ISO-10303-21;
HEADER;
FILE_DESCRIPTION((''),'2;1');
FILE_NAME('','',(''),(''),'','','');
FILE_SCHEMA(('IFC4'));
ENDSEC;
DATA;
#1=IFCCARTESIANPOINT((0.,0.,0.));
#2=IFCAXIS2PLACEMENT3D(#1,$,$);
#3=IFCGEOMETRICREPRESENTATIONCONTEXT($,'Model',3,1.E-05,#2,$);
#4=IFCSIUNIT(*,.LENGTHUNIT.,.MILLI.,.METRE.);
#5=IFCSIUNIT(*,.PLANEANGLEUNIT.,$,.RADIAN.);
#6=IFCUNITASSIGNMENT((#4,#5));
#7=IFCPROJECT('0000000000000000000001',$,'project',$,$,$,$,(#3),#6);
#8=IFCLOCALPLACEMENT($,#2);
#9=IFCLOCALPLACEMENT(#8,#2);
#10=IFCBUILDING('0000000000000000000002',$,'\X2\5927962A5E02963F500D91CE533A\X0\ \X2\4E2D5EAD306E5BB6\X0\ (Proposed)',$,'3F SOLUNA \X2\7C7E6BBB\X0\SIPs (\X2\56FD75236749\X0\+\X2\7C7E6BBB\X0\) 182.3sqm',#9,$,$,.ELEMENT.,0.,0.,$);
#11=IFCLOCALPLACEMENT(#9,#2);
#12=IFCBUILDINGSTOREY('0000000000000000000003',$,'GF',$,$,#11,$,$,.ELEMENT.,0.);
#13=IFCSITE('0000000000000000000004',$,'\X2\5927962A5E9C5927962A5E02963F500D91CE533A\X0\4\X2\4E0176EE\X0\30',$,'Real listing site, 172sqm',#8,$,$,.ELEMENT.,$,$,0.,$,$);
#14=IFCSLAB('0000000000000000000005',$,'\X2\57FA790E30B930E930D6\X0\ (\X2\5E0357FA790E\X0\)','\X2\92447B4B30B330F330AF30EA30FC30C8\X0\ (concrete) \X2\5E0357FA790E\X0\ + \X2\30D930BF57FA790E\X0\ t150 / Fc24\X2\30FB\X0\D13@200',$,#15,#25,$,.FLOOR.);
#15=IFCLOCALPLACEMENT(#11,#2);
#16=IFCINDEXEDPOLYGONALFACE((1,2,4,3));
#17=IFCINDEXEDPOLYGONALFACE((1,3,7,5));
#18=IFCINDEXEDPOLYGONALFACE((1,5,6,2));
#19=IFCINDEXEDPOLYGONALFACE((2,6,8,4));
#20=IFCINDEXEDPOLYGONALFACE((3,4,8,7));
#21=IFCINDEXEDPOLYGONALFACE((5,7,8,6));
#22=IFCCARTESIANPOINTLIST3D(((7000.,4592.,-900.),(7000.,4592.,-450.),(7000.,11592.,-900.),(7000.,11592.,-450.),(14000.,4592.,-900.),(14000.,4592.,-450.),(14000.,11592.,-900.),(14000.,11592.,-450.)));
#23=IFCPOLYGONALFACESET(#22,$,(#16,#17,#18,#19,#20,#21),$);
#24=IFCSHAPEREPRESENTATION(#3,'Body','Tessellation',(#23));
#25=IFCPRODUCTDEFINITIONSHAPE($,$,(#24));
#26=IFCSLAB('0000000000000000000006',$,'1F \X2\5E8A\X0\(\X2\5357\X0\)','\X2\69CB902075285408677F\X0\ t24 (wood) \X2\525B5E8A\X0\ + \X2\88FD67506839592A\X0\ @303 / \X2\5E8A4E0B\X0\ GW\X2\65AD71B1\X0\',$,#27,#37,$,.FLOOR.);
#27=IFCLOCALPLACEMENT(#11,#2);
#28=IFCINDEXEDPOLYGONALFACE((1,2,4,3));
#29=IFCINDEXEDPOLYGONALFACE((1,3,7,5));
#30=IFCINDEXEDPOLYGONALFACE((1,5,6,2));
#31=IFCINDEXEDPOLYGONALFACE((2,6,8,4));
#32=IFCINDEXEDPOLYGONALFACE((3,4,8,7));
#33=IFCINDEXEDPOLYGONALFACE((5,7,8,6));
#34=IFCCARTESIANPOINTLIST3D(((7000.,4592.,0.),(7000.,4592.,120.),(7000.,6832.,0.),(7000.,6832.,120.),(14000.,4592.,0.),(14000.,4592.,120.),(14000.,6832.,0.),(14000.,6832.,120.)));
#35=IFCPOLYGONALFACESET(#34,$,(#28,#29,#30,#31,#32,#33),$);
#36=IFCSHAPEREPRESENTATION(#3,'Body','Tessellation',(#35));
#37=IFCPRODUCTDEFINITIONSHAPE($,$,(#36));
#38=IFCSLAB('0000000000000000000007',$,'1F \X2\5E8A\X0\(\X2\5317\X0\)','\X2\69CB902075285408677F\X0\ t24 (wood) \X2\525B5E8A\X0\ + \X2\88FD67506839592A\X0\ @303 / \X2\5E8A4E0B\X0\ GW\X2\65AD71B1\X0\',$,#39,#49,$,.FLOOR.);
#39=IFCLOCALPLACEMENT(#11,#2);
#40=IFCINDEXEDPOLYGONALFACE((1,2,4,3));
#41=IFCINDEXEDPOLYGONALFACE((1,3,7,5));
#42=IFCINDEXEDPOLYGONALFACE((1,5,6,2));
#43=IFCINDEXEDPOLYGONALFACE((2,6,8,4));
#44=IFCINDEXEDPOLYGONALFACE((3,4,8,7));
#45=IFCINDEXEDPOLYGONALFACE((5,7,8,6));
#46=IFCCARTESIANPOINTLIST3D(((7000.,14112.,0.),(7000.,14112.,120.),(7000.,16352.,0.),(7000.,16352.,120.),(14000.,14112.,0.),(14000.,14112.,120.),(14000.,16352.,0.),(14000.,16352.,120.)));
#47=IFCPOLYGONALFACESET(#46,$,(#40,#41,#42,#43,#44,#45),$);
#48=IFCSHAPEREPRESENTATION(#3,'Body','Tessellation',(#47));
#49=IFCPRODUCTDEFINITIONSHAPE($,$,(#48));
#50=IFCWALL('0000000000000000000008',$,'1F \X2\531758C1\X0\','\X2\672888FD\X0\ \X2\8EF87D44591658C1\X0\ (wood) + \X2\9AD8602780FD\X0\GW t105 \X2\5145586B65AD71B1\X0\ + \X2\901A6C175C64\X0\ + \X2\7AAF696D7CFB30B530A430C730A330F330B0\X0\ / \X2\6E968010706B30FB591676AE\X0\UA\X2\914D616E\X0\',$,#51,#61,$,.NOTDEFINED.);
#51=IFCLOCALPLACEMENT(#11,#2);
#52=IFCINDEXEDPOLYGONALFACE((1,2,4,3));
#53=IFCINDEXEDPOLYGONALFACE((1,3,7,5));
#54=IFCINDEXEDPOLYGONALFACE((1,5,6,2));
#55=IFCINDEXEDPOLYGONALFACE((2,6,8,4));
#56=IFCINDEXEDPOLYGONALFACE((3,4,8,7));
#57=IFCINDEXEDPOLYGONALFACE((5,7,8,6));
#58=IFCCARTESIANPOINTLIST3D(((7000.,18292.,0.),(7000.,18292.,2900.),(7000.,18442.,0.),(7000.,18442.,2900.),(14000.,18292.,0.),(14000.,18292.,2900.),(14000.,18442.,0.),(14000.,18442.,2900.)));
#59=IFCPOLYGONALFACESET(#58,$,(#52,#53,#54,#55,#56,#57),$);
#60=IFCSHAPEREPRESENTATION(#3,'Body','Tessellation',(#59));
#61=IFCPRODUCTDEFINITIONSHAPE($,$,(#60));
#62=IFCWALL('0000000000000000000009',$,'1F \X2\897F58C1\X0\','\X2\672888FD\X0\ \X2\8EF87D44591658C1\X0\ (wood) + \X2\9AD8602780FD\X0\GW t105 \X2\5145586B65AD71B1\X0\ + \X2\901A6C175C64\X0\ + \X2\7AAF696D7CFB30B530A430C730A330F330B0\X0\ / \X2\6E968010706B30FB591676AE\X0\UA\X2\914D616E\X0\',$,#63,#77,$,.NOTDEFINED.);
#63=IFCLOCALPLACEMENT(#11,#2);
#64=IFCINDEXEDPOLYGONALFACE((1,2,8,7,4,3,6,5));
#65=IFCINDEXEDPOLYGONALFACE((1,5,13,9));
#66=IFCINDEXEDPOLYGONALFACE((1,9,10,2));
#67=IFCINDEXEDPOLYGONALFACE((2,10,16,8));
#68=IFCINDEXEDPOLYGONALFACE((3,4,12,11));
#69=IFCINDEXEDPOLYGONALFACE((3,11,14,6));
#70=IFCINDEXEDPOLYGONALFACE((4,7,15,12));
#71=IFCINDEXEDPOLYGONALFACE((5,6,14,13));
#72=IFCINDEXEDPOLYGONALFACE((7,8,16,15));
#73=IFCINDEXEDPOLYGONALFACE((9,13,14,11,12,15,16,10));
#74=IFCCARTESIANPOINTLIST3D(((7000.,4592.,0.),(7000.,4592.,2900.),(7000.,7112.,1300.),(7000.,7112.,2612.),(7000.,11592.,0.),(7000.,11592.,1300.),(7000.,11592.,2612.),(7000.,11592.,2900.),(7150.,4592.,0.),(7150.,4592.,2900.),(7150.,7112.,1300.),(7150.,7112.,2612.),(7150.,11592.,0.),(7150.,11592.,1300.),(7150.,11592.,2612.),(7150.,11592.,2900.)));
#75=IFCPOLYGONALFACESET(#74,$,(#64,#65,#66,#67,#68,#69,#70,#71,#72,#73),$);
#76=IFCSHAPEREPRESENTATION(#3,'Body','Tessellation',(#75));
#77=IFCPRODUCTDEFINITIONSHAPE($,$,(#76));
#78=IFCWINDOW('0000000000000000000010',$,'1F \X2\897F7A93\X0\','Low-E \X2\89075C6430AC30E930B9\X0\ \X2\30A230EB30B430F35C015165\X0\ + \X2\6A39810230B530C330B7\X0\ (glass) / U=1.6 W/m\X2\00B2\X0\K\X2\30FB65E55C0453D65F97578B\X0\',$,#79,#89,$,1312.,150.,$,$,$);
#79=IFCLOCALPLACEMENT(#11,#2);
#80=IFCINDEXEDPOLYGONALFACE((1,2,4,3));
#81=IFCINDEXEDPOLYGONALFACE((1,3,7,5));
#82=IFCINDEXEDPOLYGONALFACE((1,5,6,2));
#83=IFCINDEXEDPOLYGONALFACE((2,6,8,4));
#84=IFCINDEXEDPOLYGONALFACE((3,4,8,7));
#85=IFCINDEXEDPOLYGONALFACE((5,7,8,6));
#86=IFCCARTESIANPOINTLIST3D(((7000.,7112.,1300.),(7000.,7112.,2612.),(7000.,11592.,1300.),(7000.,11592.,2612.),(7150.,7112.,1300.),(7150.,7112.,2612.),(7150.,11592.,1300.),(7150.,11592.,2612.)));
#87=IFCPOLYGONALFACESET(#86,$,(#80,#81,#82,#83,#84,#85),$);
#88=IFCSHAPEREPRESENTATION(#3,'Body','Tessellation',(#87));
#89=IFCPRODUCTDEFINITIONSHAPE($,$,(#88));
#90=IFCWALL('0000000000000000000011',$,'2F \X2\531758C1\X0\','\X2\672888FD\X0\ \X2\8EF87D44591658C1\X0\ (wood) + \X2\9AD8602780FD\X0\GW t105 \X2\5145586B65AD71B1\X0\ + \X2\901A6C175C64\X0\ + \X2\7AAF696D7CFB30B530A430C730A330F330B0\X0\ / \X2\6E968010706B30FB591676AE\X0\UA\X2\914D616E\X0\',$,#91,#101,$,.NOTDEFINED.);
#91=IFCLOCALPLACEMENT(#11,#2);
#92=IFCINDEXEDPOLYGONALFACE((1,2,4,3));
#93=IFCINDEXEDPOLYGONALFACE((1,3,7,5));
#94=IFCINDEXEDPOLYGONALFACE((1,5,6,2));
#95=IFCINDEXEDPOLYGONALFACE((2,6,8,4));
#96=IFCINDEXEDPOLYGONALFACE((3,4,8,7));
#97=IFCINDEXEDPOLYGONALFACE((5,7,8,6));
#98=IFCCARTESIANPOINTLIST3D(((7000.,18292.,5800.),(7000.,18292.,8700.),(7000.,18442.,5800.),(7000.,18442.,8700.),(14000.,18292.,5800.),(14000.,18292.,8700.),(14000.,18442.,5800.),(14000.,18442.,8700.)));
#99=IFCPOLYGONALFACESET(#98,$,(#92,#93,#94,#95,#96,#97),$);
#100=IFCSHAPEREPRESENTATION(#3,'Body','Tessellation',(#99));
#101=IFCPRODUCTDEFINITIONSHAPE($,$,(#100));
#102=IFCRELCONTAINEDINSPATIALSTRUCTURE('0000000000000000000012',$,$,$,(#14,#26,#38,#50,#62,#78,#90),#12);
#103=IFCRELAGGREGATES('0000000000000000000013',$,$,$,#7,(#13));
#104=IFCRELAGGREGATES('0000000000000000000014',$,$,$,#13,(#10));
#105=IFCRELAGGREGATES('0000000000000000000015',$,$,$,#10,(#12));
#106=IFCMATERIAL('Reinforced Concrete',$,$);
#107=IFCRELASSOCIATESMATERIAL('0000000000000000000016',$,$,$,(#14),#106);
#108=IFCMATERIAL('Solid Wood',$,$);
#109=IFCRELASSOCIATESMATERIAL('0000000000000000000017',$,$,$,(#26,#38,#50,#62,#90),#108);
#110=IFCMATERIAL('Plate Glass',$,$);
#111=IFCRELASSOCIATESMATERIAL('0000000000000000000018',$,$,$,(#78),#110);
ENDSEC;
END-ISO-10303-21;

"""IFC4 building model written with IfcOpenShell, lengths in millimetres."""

from ifc_helpers import new_model, si_unit, frame, frame_2d, origin, place, context, project, spatial, rectangle, extrude, material, element, fill, save


model = new_model("IFC4")

# Units and contexts
model_context = context("Model", 3, precision=1e-05, world=origin())
ifc_project = project(units=[si_unit("LENGTHUNIT", "METRE", prefix="MILLI"), si_unit("PLANEANGLEUNIT", "RADIAN")], contexts=[model_context])

# Site, building, storey
site_placement = place(None, origin())
site = spatial("IfcSite", under=ifc_project, at=site_placement, Name="大阪府大阪市阿倍野区4丁目30", ObjectType="Real listing site, 172sqm", CompositionType="ELEMENT", RefElevation=0.0)
building_placement = place(site_placement, origin())
building = spatial("IfcBuilding", under=site, at=building_placement, Name="大阪市阿倍野区 中庭の家 (Proposed)", ObjectType="3F SOLUNA 籾殻SIPs (国産杉+籾殻) 182.3sqm", CompositionType="ELEMENT", ElevationOfRefHeight=0.0, ElevationOfTerrain=0.0)
storey_placement = place(building_placement, origin())
storey = spatial("IfcBuildingStorey", under=building, at=storey_placement, Name="GF", CompositionType="ELEMENT", Elevation=0.0)

# Slabs
ifc_material_1 = material(Name="Reinforced Concrete")
slab_1_placement = place(storey_placement, frame((3500.0, 2296.0, -450.0)))
element("IfcSlab", 1, at=slab_1_placement, inside=storey, material=ifc_material_1, Name="基礎スラブ (布基礎)", Description="鉄筋コンクリート (concrete) 布基礎 + ベタ基礎 t150 / Fc24・D13@200", PredefinedType="FLOOR", context=model_context, shape_type="SweptSolid", body=[
    extrude(rectangle(XDim=7000.0, YDim=7000.0, at=frame_2d((3500.0, 3500.0))), frame((3500.0, 2296.0, -450.0)), (0.0, 0.0, 1.0), 450.0),
])
ifc_material_2 = material(Name="Solid Wood")
slab_2_placement = place(storey_placement, frame((3500.0, 2296.0, 0.0)))
element("IfcSlab", 2, at=slab_2_placement, inside=storey, material=ifc_material_2, Name="1F 床(南)", Description="構造用合板 t24 (wood) 剛床 + 製材根太 @303 / 床下 GW断熱", PredefinedType="FLOOR", context=model_context, shape_type="SweptSolid", body=[
    extrude(rectangle(XDim=7000.0, YDim=2240.0, at=frame_2d((3500.0, 1120.0))), frame((3500.0, 2296.0, 0.0)), (0.0, 0.0, 1.0), 120.0),
])
slab_3_placement = place(storey_placement, frame((3500.0, 7056.0, 0.0)))
element("IfcSlab", 3, at=slab_3_placement, inside=storey, material=ifc_material_2, Name="1F 床(北)", Description="構造用合板 t24 (wood) 剛床 + 製材根太 @303 / 床下 GW断熱", PredefinedType="FLOOR", context=model_context, shape_type="SweptSolid", body=[
    extrude(rectangle(XDim=7000.0, YDim=2240.0, at=frame_2d((3500.0, 1120.0))), frame((3500.0, 7056.0, 0.0)), (0.0, 0.0, 1.0), 120.0),
])

# Shared definitions
ifc_material_3 = material(Name="Plate Glass")

# Wall
wall_1_placement = place(storey_placement, frame((3500.0, 9146.0, 0.0)))
element("IfcWall", 4, at=wall_1_placement, inside=storey, material=ifc_material_2, Name="1F 北壁", Description="木製 軸組外壁 (wood) + 高性能GW t105 充填断熱 + 通気層 + 窯業系サイディング / 準耐火・外皮UA配慮", PredefinedType="NOTDEFINED", context=model_context, shape_type="SweptSolid", body=[
    extrude(rectangle(XDim=7000.0, YDim=150.0, at=frame_2d((3500.0, 75.0))), frame((3500.0, 9146.0, 0.0)), (0.0, 0.0, 1.0), 2900.0),
])

# Wall, opening, window
wall_2_placement = place(storey_placement, frame((3500.0, 2296.0, 0.0)))
wall_2 = element("IfcWall", 5, at=wall_2_placement, inside=storey, material=ifc_material_2, Name="1F 西壁", Description="木製 軸組外壁 (wood) + 高性能GW t105 充填断熱 + 通気層 + 窯業系サイディング / 準耐火・外皮UA配慮", PredefinedType="NOTDEFINED", context=model_context, shape_type="SweptSolid", body=[
    extrude(rectangle(XDim=150.0, YDim=7000.0, at=frame_2d((75.0, 3500.0))), frame((3500.0, 2296.0, 0.0)), (0.0, 0.0, 1.0), 2900.0),
])
opening_1_placement = place(storey_placement, frame((3500.0, 3556.0, 650.0)))
opening_1 = element("IfcOpeningElement", 6, at=opening_1_placement, cuts=wall_2, PredefinedType="NOTDEFINED", context=model_context, shape_type="SweptSolid", body=[
    extrude(rectangle(XDim=150.0, YDim=4480.0, at=frame_2d((75.0, 2240.0))), frame((3500.0, 3556.0, 650.0)), (0.0, 0.0, 1.0), 1312.0),
])
window_1_placement = place(storey_placement, frame((3500.0, 3556.0, 650.0)))
window_1 = element("IfcWindow", 7, at=window_1_placement, inside=storey, material=ifc_material_3, Name="1F 西窓", Description="Low-E 複層ガラス アルゴン封入 + 樹脂サッシ (glass) / U=1.6 W/m²K・日射取得型", OverallHeight=1312.0, OverallWidth=150.0, context=model_context, shape_type="SweptSolid", body=[
    extrude(rectangle(XDim=150.0, YDim=4480.0, at=frame_2d((75.0, 2240.0))), frame((3500.0, 3556.0, 650.0)), (0.0, 0.0, 1.0), 1312.0),
])
fill(opening_1, window_1)

# Wall
wall_3_placement = place(storey_placement, frame((3500.0, 9146.0, 2900.0)))
element("IfcWall", 8, at=wall_3_placement, inside=storey, material=ifc_material_2, Name="2F 北壁", Description="木製 軸組外壁 (wood) + 高性能GW t105 充填断熱 + 通気層 + 窯業系サイディング / 準耐火・外皮UA配慮", PredefinedType="NOTDEFINED", context=model_context, shape_type="SweptSolid", body=[
    extrude(rectangle(XDim=7000.0, YDim=150.0, at=frame_2d((3500.0, 75.0))), frame((3500.0, 9146.0, 2900.0)), (0.0, 0.0, 1.0), 2900.0),
])

save(model, "model.ifc")
